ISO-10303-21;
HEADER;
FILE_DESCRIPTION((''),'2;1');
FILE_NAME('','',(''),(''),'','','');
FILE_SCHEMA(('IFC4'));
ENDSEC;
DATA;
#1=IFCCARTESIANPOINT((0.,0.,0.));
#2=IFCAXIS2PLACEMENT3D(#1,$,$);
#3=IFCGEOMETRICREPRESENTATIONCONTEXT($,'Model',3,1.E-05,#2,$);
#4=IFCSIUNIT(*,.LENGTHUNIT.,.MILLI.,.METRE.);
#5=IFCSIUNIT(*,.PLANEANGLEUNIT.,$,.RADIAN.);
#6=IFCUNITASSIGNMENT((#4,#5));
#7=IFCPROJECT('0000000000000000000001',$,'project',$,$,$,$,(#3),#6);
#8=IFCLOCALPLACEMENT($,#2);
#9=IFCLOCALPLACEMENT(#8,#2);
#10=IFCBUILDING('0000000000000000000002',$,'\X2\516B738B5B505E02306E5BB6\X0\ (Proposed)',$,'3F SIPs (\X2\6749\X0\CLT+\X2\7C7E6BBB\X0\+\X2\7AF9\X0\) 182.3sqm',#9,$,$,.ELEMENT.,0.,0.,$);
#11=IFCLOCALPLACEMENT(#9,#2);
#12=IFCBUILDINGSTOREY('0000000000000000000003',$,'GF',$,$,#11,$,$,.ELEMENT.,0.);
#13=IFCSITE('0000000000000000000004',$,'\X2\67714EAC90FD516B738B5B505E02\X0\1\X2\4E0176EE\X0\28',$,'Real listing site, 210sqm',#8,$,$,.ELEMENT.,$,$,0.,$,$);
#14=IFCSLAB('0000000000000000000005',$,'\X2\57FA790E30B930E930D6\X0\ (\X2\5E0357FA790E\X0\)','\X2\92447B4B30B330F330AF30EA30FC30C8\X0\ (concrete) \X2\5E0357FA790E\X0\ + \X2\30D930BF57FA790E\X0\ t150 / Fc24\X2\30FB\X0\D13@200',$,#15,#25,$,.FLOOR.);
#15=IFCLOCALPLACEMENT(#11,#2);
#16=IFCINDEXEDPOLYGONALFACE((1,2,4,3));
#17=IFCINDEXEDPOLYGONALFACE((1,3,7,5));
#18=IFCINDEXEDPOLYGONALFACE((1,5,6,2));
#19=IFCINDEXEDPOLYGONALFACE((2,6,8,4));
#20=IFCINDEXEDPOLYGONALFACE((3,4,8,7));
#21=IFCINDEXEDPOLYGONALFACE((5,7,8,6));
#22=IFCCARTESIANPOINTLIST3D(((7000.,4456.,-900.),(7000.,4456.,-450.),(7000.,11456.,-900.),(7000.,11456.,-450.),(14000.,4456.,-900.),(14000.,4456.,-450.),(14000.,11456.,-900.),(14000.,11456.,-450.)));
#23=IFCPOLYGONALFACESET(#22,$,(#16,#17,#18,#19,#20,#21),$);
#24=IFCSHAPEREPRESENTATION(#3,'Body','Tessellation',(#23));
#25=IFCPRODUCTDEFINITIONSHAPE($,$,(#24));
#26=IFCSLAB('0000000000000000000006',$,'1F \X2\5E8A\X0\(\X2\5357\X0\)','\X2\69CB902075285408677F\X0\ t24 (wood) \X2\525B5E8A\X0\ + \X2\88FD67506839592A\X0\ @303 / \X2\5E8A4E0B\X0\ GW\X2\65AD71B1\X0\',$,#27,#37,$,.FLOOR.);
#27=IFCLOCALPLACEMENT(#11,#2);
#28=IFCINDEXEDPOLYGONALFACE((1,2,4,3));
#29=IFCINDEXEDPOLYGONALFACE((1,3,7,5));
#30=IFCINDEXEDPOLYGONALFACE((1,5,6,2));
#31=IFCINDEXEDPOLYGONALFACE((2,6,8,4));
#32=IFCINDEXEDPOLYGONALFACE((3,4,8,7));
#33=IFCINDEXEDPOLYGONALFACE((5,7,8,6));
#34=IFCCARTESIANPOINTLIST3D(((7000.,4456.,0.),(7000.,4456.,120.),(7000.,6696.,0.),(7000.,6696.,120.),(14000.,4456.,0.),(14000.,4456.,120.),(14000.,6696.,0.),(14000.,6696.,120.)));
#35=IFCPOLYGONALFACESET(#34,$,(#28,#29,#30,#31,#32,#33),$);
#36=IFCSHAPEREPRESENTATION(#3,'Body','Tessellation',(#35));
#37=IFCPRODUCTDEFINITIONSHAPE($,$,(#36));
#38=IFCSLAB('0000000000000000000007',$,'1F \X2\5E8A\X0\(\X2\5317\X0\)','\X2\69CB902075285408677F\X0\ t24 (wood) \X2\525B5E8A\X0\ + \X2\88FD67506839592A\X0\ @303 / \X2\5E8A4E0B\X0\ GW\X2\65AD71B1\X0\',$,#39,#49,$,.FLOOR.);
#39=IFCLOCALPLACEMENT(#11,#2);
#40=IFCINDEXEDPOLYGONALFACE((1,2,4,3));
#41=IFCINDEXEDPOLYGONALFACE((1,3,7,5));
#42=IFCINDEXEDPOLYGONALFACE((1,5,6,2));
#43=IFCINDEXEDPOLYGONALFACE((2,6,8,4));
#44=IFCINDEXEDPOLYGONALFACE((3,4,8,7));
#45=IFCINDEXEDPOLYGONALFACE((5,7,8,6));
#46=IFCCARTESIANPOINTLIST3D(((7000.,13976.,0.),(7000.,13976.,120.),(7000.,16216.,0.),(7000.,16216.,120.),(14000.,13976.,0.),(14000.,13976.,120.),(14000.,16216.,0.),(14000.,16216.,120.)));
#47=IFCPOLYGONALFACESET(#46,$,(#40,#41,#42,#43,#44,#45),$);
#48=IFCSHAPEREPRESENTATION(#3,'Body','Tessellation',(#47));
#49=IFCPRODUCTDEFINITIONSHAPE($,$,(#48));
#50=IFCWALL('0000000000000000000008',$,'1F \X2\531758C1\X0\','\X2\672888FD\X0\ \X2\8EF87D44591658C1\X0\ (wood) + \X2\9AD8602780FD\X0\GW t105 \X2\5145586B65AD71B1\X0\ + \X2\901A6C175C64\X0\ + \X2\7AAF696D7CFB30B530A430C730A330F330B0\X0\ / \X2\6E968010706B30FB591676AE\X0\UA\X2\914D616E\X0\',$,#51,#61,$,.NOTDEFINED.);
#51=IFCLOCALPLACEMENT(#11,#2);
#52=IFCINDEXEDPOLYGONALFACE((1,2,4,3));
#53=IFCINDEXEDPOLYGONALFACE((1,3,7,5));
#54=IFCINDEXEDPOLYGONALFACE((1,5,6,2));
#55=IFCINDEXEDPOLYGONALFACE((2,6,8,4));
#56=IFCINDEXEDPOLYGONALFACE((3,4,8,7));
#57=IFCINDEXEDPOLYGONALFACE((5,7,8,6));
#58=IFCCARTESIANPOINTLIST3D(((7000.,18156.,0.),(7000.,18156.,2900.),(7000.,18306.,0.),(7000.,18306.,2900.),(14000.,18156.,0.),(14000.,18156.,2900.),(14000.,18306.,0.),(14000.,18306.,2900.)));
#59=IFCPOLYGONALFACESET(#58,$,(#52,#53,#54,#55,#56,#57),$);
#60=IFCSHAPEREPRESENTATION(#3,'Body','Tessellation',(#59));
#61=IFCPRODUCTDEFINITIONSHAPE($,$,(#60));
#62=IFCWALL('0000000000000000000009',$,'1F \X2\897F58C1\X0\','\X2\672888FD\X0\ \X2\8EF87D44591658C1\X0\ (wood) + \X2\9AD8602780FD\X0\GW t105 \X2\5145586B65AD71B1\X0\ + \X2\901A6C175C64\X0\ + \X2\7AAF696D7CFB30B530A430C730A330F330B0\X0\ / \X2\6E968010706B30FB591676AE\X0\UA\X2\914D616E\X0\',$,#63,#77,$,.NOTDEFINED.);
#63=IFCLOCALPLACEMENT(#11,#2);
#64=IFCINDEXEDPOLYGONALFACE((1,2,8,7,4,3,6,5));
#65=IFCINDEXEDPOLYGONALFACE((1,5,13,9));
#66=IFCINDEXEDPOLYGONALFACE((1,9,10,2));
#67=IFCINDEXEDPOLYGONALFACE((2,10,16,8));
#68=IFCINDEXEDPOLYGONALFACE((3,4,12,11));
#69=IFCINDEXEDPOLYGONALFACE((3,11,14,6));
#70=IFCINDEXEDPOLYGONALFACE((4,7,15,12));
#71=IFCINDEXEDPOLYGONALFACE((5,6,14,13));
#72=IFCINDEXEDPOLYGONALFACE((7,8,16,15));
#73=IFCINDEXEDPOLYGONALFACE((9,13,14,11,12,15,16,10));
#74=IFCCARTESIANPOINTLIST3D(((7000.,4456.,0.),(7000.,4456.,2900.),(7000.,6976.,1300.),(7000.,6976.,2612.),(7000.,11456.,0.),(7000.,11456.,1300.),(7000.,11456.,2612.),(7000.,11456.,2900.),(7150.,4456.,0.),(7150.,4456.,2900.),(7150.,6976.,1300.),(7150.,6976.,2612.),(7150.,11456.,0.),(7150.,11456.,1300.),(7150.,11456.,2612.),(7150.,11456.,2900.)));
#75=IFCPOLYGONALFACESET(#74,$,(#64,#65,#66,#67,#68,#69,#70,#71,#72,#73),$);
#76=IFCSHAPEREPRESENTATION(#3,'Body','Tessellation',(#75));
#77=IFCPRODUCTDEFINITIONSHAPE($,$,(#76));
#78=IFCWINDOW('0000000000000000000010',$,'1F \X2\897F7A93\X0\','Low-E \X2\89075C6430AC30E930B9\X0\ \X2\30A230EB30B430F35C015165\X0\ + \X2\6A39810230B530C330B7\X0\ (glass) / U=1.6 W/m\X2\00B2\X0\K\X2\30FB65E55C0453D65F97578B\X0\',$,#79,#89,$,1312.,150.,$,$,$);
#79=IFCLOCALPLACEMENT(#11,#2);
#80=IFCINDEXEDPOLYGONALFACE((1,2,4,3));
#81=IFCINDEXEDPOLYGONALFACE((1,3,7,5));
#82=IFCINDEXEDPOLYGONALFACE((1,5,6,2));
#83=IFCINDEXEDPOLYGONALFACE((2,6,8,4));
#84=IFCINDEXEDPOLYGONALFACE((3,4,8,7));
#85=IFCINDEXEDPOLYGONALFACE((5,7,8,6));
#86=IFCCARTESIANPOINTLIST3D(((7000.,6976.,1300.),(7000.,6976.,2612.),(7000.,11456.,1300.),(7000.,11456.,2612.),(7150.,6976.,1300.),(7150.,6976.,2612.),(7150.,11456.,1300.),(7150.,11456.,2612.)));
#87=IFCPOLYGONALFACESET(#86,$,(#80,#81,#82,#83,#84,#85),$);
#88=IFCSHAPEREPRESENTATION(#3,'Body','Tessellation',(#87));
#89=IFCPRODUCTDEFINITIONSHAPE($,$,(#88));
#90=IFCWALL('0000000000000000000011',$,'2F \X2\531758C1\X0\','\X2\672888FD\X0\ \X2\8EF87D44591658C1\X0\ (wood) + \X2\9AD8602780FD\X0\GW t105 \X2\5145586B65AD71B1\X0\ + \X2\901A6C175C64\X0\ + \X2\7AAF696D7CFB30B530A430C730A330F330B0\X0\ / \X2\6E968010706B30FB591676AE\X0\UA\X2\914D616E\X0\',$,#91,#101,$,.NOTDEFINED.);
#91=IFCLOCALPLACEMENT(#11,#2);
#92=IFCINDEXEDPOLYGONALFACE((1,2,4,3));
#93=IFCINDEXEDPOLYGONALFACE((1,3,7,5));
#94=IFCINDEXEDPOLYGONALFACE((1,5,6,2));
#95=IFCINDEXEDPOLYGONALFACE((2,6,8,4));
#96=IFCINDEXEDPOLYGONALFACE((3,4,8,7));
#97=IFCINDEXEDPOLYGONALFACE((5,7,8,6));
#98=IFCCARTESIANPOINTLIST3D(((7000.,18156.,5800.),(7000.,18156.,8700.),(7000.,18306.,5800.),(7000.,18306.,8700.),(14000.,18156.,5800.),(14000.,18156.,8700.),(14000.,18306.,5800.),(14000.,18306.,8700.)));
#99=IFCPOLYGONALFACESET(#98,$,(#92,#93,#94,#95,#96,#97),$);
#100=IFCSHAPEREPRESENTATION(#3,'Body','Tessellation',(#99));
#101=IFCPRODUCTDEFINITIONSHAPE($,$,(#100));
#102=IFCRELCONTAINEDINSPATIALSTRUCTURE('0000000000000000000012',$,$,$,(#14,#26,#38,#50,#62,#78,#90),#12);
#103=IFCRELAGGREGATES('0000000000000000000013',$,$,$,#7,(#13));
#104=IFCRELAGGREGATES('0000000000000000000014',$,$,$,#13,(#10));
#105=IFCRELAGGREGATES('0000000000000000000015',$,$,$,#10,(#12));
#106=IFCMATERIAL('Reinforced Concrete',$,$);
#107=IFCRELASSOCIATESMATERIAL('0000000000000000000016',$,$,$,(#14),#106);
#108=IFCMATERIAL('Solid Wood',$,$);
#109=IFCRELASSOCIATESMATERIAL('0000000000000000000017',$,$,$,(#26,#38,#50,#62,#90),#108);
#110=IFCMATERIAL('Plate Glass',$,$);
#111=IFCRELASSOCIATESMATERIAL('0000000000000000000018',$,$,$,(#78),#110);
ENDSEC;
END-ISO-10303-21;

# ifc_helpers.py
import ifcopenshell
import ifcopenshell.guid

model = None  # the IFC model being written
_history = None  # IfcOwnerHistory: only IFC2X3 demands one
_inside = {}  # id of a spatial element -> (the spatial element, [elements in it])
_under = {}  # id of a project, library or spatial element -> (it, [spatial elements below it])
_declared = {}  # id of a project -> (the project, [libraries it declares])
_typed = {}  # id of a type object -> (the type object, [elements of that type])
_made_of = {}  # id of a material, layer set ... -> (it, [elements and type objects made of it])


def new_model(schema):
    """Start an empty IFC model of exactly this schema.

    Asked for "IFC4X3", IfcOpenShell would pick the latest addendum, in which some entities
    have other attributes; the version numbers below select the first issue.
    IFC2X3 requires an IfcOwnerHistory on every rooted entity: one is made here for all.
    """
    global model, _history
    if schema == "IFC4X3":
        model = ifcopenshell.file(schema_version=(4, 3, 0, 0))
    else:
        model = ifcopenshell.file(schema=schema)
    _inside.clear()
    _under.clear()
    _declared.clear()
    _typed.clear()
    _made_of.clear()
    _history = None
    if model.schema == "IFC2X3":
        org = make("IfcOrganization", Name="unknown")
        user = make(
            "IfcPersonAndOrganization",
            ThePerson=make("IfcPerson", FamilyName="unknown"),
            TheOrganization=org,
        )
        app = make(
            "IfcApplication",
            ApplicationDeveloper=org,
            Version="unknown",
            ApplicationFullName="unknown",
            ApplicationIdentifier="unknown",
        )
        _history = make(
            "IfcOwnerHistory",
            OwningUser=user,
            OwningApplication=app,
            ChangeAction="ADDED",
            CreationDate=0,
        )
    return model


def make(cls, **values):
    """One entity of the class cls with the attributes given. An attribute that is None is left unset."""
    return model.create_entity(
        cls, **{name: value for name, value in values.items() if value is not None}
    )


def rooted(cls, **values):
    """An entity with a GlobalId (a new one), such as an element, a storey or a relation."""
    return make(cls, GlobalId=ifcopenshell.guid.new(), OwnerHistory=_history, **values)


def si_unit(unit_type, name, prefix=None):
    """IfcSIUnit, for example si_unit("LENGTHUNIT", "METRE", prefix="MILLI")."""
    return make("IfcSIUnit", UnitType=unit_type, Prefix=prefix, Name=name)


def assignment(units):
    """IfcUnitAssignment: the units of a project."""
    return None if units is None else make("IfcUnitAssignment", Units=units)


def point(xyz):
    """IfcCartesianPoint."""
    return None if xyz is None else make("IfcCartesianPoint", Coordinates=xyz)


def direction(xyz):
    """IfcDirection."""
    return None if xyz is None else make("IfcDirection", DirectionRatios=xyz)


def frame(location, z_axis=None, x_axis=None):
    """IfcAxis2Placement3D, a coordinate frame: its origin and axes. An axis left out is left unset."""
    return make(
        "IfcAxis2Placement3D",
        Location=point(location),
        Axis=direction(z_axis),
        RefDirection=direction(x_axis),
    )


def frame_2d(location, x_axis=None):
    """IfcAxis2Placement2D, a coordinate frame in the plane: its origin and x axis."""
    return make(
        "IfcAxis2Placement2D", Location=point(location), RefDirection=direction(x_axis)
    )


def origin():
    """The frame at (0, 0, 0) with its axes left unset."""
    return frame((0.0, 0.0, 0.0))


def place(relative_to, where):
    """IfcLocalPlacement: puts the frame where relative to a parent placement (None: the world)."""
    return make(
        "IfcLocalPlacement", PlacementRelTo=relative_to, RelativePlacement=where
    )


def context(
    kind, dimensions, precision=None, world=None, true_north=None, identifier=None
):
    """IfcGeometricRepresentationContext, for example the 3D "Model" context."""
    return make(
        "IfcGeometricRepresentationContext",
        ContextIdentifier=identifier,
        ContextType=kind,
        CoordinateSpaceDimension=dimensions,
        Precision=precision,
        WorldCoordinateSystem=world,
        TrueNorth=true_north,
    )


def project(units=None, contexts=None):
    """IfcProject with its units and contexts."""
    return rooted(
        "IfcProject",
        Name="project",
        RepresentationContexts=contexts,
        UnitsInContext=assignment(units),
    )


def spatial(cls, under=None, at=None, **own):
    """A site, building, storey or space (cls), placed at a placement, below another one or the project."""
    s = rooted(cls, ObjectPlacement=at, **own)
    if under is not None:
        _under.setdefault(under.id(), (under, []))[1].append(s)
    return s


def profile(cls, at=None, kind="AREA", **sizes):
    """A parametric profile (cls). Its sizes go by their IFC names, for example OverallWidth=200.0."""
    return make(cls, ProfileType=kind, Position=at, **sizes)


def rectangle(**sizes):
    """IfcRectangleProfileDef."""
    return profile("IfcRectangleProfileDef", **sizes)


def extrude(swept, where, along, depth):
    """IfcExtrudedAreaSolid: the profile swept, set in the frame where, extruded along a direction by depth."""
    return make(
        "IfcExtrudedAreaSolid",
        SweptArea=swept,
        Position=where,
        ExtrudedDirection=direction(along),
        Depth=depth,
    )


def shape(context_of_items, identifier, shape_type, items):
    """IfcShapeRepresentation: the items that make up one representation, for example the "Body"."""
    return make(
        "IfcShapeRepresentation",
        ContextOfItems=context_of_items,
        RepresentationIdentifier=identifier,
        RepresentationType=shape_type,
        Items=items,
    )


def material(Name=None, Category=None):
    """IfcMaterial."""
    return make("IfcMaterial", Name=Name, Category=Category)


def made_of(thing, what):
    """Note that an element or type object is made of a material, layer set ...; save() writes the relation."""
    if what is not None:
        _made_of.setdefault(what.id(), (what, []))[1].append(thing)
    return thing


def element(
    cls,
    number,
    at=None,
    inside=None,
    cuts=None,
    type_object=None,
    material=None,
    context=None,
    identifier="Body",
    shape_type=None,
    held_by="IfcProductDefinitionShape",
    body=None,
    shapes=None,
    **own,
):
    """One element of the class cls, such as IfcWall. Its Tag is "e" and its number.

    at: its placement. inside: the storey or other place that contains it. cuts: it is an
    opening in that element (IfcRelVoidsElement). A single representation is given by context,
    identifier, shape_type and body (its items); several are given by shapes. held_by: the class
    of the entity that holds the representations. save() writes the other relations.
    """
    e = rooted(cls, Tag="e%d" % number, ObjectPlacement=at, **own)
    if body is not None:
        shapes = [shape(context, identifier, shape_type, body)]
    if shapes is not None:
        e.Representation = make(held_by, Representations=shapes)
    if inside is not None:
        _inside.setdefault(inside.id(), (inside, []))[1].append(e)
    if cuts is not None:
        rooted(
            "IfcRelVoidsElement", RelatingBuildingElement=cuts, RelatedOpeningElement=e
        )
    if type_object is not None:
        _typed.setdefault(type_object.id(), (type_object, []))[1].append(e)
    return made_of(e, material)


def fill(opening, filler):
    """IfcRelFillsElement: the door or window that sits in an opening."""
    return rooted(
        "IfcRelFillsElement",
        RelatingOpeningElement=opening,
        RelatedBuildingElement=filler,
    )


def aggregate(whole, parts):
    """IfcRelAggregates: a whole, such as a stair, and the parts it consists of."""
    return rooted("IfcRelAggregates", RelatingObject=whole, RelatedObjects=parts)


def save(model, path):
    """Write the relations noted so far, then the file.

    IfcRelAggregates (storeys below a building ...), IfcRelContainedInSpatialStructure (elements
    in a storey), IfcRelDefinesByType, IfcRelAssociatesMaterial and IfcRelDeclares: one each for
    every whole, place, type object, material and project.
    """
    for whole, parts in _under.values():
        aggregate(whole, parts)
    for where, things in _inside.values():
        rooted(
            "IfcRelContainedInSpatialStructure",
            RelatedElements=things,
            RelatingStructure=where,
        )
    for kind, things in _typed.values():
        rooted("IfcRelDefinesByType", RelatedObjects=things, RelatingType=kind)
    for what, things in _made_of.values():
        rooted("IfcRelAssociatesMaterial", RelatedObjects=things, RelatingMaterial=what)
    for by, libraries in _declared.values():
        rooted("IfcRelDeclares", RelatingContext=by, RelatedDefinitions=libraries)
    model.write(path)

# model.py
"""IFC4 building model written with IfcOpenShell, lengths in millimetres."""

from ifc_helpers import new_model, si_unit, frame, frame_2d, origin, place, context, project, spatial, rectangle, extrude, material, element, fill, save


model = new_model("IFC4")

# Units and contexts
model_context = context("Model", 3, precision=1e-05, world=origin())
ifc_project = project(units=[si_unit("LENGTHUNIT", "METRE", prefix="MILLI"), si_unit("PLANEANGLEUNIT", "RADIAN")], contexts=[model_context])

# Site, building, storey
site_placement = place(None, origin())
site = spatial("IfcSite", under=ifc_project, at=site_placement, Name="東京都八王子市1丁目28", ObjectType="Real listing site, 210sqm", CompositionType="ELEMENT", RefElevation=0.0)
building_placement = place(site_placement, origin())
building = spatial("IfcBuilding", under=site, at=building_placement, Name="八王子市の家 (Proposed)", ObjectType="3F SIPs (杉CLT+籾殻+竹) 182.3sqm", CompositionType="ELEMENT", ElevationOfRefHeight=0.0, ElevationOfTerrain=0.0)
storey_placement = place(building_placement, origin())
storey = spatial("IfcBuildingStorey", under=building, at=storey_placement, Name="GF", CompositionType="ELEMENT", Elevation=0.0)

# Slabs
ifc_material_1 = material(Name="Reinforced Concrete")
slab_1_placement = place(storey_placement, frame((3500.0, 2228.0, -450.0)))
element("IfcSlab", 1, at=slab_1_placement, inside=storey, material=ifc_material_1, Name="基礎スラブ (布基礎)", Description="鉄筋コンクリート (concrete) 布基礎 + ベタ基礎 t150 / Fc24・D13@200", PredefinedType="FLOOR", context=model_context, shape_type="SweptSolid", body=[
    extrude(rectangle(XDim=7000.0, YDim=7000.0, at=frame_2d((3500.0, 3500.0))), frame((3500.0, 2228.0, -450.0)), (0.0, 0.0, 1.0), 450.0),
])
ifc_material_2 = material(Name="Solid Wood")
slab_2_placement = place(storey_placement, frame((3500.0, 2228.0, 0.0)))
element("IfcSlab", 2, at=slab_2_placement, inside=storey, material=ifc_material_2, Name="1F 床(南)", Description="構造用合板 t24 (wood) 剛床 + 製材根太 @303 / 床下 GW断熱", PredefinedType="FLOOR", context=model_context, shape_type="SweptSolid", body=[
    extrude(rectangle(XDim=7000.0, YDim=2240.0, at=frame_2d((3500.0, 1120.0))), frame((3500.0, 2228.0, 0.0)), (0.0, 0.0, 1.0), 120.0),
])
slab_3_placement = place(storey_placement, frame((3500.0, 6988.0, 0.0)))
element("IfcSlab", 3, at=slab_3_placement, inside=storey, material=ifc_material_2, Name="1F 床(北)", Description="構造用合板 t24 (wood) 剛床 + 製材根太 @303 / 床下 GW断熱", PredefinedType="FLOOR", context=model_context, shape_type="SweptSolid", body=[
    extrude(rectangle(XDim=7000.0, YDim=2240.0, at=frame_2d((3500.0, 1120.0))), frame((3500.0, 6988.0, 0.0)), (0.0, 0.0, 1.0), 120.0),
])

# Shared definitions
ifc_material_3 = material(Name="Plate Glass")

# Wall
wall_1_placement = place(storey_placement, frame((3500.0, 9078.0, 0.0)))
element("IfcWall", 4, at=wall_1_placement, inside=storey, material=ifc_material_2, Name="1F 北壁", Description="木製 軸組外壁 (wood) + 高性能GW t105 充填断熱 + 通気層 + 窯業系サイディング / 準耐火・外皮UA配慮", PredefinedType="NOTDEFINED", context=model_context, shape_type="SweptSolid", body=[
    extrude(rectangle(XDim=7000.0, YDim=150.0, at=frame_2d((3500.0, 75.0))), frame((3500.0, 9078.0, 0.0)), (0.0, 0.0, 1.0), 2900.0),
])

# Wall, opening, window
wall_2_placement = place(storey_placement, frame((3500.0, 2228.0, 0.0)))
wall_2 = element("IfcWall", 5, at=wall_2_placement, inside=storey, material=ifc_material_2, Name="1F 西壁", Description="木製 軸組外壁 (wood) + 高性能GW t105 充填断熱 + 通気層 + 窯業系サイディング / 準耐火・外皮UA配慮", PredefinedType="NOTDEFINED", context=model_context, shape_type="SweptSolid", body=[
    extrude(rectangle(XDim=150.0, YDim=7000.0, at=frame_2d((75.0, 3500.0))), frame((3500.0, 2228.0, 0.0)), (0.0, 0.0, 1.0), 2900.0),
])
opening_1_placement = place(storey_placement, frame((3500.0, 3488.0, 650.0)))
opening_1 = element("IfcOpeningElement", 6, at=opening_1_placement, cuts=wall_2, PredefinedType="NOTDEFINED", context=model_context, shape_type="SweptSolid", body=[
    extrude(rectangle(XDim=150.0, YDim=4480.0, at=frame_2d((75.0, 2240.0))), frame((3500.0, 3488.0, 650.0)), (0.0, 0.0, 1.0), 1312.0),
])
window_1_placement = place(storey_placement, frame((3500.0, 3488.0, 650.0)))
window_1 = element("IfcWindow", 7, at=window_1_placement, inside=storey, material=ifc_material_3, Name="1F 西窓", Description="Low-E 複層ガラス アルゴン封入 + 樹脂サッシ (glass) / U=1.6 W/m²K・日射取得型", OverallHeight=1312.0, OverallWidth=150.0, context=model_context, shape_type="SweptSolid", body=[
    extrude(rectangle(XDim=150.0, YDim=4480.0, at=frame_2d((75.0, 2240.0))), frame((3500.0, 3488.0, 650.0)), (0.0, 0.0, 1.0), 1312.0),
])
fill(opening_1, window_1)

# Wall
wall_3_placement = place(storey_placement, frame((3500.0, 9078.0, 2900.0)))
element("IfcWall", 8, at=wall_3_placement, inside=storey, material=ifc_material_2, Name="2F 北壁", Description="木製 軸組外壁 (wood) + 高性能GW t105 充填断熱 + 通気層 + 窯業系サイディング / 準耐火・外皮UA配慮", PredefinedType="NOTDEFINED", context=model_context, shape_type="SweptSolid", body=[
    extrude(rectangle(XDim=7000.0, YDim=150.0, at=frame_2d((3500.0, 75.0))), frame((3500.0, 9078.0, 2900.0)), (0.0, 0.0, 1.0), 2900.0),
])

save(model, "model.ifc")
